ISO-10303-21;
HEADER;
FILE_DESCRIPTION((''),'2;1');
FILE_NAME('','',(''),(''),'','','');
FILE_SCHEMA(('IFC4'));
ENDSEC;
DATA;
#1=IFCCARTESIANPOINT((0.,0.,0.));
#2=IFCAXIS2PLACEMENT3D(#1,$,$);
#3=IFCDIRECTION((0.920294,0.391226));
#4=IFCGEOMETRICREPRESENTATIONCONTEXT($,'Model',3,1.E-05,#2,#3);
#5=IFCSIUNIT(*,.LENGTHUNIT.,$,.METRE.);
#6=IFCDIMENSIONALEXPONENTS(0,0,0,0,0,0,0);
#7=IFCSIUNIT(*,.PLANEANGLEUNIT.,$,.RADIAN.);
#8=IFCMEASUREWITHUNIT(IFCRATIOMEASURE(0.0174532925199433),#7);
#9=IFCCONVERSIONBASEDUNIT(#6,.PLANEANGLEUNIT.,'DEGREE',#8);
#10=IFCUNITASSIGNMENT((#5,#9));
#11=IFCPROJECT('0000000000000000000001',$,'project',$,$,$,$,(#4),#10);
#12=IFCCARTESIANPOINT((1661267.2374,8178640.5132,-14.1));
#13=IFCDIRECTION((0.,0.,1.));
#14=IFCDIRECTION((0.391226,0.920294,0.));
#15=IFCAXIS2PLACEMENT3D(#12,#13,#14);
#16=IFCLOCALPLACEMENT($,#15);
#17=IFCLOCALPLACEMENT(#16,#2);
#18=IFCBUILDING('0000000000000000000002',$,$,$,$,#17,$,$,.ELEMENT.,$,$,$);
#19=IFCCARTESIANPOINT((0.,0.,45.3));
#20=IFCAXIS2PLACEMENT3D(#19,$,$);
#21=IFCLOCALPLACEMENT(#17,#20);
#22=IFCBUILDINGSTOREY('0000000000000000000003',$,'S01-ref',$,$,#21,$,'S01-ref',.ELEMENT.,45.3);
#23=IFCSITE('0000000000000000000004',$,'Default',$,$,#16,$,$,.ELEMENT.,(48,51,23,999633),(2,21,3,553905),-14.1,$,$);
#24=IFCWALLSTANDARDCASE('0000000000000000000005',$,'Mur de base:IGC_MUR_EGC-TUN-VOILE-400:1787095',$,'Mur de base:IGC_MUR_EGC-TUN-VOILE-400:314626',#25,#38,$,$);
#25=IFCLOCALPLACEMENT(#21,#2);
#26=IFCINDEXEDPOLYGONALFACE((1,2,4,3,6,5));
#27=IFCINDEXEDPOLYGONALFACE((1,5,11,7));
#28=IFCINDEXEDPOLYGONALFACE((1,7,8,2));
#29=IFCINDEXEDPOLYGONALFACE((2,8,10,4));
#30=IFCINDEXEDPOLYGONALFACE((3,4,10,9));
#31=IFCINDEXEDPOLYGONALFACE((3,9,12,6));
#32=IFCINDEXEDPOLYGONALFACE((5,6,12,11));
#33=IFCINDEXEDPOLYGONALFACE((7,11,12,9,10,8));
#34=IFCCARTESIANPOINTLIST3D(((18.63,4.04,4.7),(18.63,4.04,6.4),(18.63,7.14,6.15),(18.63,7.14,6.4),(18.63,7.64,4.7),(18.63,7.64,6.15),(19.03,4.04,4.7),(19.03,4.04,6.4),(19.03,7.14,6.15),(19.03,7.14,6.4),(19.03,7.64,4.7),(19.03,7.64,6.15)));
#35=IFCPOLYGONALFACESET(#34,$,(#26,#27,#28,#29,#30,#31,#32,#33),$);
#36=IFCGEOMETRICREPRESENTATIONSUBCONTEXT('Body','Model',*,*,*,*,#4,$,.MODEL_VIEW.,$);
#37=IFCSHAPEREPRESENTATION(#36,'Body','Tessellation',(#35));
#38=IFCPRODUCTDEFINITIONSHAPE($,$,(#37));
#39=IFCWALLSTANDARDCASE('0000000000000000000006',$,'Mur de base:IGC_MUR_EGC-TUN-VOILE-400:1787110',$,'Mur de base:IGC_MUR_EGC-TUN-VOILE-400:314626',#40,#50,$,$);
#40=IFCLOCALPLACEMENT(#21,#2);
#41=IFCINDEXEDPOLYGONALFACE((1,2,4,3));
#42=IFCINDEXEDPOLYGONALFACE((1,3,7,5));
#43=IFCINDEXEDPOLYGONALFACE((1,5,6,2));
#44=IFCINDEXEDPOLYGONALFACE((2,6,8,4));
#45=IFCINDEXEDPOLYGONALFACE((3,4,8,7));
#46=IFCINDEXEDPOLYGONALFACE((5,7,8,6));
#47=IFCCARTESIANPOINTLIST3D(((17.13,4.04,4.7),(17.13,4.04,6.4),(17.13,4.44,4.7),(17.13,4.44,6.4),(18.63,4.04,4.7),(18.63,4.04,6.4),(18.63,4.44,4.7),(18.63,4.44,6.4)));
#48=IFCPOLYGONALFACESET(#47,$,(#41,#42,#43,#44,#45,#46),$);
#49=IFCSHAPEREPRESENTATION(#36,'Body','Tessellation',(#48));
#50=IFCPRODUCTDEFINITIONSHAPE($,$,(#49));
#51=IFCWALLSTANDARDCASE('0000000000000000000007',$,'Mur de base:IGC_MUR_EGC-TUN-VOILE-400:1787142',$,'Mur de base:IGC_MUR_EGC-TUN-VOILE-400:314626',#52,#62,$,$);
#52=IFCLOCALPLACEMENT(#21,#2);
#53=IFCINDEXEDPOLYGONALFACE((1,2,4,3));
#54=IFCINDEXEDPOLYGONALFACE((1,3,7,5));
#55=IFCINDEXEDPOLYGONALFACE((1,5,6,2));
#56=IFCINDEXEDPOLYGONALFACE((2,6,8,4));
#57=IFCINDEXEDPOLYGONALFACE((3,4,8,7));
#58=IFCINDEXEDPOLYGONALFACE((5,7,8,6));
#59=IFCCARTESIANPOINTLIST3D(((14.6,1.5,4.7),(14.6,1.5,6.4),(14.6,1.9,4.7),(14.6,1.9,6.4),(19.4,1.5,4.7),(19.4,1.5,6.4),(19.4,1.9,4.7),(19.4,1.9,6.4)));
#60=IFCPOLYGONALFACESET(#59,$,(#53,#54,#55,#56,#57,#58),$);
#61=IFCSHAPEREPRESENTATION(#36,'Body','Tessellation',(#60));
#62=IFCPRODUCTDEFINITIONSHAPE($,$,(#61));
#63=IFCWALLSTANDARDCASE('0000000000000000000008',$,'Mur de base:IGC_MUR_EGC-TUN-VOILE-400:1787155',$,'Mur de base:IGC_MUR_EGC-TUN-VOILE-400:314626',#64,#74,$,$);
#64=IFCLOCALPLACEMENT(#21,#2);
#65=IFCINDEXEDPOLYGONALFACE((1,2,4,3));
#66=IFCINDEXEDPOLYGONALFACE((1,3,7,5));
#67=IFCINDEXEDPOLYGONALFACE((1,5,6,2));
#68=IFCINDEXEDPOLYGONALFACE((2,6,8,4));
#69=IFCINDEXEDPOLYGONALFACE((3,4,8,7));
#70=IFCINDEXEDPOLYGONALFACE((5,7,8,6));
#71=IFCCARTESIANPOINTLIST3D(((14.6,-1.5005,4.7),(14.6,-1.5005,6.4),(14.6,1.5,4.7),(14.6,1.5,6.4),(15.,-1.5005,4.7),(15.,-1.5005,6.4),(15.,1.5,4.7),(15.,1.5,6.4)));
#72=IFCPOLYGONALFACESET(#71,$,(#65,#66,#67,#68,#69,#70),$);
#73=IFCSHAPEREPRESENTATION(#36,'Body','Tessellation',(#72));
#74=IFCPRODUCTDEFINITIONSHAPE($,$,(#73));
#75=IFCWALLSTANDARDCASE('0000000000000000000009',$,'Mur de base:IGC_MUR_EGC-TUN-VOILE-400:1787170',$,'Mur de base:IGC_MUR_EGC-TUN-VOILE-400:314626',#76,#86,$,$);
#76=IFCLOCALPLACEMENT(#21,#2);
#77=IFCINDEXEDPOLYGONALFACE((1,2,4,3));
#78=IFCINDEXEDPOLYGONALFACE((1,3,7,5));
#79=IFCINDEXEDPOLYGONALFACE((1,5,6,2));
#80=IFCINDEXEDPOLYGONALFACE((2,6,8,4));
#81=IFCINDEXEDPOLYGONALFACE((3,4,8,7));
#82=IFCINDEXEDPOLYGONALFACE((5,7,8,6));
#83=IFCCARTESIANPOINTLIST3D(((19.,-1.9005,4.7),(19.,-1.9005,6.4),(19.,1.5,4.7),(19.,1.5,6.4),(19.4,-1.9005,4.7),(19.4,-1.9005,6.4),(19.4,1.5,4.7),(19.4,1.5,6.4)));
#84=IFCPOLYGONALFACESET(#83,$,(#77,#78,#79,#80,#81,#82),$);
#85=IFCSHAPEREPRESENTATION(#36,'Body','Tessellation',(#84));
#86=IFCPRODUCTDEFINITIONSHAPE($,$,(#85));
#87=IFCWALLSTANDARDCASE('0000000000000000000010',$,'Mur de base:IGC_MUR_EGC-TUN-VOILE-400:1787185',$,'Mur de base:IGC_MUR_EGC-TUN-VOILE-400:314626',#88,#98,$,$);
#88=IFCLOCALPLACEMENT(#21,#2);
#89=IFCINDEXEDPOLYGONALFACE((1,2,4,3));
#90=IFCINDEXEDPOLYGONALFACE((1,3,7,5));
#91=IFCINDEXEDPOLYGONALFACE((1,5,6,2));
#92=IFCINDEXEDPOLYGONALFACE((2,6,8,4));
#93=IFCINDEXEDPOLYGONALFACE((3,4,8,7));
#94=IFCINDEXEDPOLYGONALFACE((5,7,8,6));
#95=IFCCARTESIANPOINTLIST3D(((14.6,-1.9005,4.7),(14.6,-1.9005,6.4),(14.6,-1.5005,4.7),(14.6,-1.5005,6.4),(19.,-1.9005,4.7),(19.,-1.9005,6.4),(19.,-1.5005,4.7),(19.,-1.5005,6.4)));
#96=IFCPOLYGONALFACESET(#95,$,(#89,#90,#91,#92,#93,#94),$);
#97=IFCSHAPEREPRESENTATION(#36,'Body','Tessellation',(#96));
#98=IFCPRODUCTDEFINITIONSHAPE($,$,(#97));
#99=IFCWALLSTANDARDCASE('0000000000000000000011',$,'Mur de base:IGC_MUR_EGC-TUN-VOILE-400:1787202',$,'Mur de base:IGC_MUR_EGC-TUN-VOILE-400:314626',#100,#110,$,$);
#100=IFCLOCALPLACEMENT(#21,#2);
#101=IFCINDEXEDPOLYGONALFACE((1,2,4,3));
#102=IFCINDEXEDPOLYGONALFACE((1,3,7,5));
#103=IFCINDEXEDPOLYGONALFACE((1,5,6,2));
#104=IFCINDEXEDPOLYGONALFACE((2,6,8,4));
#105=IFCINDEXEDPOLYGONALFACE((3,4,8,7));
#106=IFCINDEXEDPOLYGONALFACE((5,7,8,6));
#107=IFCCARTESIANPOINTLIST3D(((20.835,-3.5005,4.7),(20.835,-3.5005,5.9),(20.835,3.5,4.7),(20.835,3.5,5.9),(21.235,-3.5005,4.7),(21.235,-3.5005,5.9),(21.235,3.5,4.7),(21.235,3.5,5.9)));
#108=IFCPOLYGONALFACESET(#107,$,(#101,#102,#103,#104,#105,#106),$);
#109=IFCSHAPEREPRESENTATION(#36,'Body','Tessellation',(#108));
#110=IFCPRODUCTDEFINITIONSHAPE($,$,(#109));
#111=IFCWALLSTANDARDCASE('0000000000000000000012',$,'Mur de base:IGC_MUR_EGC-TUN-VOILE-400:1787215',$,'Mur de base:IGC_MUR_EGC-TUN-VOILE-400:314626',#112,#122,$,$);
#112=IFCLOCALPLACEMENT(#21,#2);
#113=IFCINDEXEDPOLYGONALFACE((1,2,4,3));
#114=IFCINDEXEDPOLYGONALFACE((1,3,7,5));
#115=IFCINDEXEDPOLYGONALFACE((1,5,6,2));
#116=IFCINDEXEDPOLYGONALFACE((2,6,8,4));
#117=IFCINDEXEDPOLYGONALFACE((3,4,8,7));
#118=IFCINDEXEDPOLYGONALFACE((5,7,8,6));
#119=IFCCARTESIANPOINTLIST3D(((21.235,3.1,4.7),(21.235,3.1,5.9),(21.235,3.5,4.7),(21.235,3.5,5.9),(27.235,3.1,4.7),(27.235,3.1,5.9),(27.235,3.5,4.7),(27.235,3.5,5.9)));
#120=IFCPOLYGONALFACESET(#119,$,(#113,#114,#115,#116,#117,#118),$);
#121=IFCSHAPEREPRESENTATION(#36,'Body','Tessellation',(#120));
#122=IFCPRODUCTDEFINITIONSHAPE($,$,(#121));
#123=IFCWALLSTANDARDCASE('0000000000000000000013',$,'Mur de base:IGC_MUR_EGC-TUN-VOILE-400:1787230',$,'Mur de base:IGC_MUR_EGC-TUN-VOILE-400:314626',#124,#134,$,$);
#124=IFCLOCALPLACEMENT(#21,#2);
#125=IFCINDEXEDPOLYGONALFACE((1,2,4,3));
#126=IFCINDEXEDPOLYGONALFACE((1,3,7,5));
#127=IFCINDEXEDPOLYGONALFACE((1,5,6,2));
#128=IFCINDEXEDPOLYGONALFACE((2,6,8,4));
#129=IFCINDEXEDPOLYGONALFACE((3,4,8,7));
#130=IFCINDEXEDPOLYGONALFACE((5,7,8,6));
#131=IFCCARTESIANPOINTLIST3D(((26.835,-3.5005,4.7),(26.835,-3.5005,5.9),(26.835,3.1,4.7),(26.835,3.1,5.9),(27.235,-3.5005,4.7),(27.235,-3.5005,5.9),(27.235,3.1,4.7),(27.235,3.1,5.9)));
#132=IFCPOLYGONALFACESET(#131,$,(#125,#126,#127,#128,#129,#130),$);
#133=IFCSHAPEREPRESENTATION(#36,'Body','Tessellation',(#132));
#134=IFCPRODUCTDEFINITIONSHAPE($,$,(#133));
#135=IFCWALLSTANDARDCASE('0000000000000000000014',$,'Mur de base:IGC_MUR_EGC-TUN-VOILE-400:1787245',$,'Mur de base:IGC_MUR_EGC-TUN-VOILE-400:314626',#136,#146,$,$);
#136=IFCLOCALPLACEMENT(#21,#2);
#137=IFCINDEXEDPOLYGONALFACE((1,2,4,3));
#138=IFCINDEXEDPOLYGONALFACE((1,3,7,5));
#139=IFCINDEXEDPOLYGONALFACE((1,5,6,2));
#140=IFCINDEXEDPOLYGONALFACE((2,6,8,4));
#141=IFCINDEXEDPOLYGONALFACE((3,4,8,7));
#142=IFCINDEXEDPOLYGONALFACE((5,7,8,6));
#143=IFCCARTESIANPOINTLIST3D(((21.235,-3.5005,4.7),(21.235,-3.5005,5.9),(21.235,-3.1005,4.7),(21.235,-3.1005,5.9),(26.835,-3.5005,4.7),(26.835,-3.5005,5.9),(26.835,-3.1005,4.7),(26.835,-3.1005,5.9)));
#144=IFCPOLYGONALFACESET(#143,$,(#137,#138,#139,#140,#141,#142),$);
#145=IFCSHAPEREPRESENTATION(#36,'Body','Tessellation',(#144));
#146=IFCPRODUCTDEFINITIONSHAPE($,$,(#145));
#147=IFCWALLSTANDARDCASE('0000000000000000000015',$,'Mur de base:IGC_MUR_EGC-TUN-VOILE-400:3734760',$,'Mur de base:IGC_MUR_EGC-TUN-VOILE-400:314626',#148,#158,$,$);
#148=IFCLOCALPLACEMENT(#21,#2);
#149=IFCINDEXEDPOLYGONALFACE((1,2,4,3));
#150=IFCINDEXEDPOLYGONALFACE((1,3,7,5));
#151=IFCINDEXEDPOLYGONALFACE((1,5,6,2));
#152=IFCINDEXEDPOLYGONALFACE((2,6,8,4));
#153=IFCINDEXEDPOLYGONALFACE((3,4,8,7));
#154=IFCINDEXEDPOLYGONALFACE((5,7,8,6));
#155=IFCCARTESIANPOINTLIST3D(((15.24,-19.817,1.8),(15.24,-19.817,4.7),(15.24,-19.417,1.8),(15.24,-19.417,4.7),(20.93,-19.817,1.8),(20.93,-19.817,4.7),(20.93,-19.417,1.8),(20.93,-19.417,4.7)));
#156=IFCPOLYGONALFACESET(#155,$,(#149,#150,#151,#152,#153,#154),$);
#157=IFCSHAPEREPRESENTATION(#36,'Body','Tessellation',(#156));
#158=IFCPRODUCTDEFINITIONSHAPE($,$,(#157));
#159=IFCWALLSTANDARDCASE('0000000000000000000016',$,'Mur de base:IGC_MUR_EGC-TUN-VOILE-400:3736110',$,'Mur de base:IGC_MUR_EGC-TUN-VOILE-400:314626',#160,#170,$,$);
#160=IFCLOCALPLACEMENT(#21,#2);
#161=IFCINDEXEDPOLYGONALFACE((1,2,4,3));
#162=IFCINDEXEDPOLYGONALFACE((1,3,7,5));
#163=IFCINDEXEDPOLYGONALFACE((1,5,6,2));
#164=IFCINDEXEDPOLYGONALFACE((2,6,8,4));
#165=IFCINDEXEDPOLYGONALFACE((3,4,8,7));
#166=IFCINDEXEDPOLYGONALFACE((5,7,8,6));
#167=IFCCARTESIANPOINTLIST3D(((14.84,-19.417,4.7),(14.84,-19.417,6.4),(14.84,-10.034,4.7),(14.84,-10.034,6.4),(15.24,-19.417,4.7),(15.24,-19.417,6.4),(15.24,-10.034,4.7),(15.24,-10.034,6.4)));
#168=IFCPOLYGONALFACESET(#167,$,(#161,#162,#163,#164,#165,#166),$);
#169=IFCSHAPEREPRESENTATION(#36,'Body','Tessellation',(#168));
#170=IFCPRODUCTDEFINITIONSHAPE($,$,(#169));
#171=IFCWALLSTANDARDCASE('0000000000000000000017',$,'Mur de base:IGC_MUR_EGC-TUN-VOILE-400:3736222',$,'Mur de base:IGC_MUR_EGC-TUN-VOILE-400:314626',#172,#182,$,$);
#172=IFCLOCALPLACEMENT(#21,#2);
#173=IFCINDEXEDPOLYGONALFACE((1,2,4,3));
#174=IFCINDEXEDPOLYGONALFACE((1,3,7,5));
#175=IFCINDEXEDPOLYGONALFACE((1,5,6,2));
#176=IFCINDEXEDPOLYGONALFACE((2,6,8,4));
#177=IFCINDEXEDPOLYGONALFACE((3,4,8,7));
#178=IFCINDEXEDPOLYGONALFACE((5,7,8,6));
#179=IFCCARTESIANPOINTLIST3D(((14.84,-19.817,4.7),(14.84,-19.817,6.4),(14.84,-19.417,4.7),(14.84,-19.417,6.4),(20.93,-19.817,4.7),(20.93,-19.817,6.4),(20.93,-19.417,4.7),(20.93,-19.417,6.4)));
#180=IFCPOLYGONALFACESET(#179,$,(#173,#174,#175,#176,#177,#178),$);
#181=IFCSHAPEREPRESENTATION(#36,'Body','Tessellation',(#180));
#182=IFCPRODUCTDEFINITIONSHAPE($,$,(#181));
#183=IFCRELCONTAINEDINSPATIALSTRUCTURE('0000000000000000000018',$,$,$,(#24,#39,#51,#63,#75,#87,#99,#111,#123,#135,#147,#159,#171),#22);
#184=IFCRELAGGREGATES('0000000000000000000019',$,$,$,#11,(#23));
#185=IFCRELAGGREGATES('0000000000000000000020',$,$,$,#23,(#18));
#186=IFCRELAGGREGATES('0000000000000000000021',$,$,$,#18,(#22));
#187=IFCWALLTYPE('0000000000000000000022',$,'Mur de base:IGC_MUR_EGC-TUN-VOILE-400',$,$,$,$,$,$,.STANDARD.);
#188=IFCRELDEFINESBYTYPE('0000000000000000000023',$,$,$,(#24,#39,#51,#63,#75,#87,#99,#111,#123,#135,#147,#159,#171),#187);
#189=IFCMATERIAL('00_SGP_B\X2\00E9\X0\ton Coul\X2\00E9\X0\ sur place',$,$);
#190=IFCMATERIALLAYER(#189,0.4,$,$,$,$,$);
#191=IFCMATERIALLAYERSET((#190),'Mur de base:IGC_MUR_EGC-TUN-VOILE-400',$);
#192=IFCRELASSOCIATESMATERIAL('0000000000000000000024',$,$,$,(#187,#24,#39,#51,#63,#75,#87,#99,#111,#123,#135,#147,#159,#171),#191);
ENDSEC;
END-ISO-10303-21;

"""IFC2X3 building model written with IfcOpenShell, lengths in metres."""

from ifc_helpers import new_model, entity, si_unit, converted_unit, direction, frame, frame_2d, origin, place, context, subcontext, project, spatial, rectangle, extrude, material, layer, layer_set, layer_usage, type_object, element, save


model = new_model("IFC2X3")

# Units and contexts
model_context = context("Model", 3, precision=1e-05, world=origin(), true_north=direction((0.920294, 0.391226)))
body_context = subcontext(model_context, "Body", "Model", "MODEL_VIEW")
ifc_project = project(units=[si_unit("LENGTHUNIT", "METRE"), converted_unit("PLANEANGLEUNIT", "DEGREE", entity("IfcRatioMeasure", 0.0174532925199433), si_unit("PLANEANGLEUNIT", "RADIAN"), dimensions=[0, 0, 0, 0, 0, 0, 0])], contexts=[model_context])

# Site, building, storey
site_placement = place(None, frame((1661267.2374, 8178640.5132, -14.1), z_axis=(0.0, 0.0, 1.0), x_axis=(0.391226, 0.920294, 0.0)))
site = spatial("IfcSite", under=ifc_project, at=site_placement, Name="Default", CompositionType="ELEMENT", RefLatitude=(48, 51, 23, 999633), RefLongitude=(2, 21, 3, 553905), RefElevation=-14.1)
building_placement = place(site_placement, origin())
building = spatial("IfcBuilding", under=site, at=building_placement, CompositionType="ELEMENT")
storey_placement = place(building_placement, frame((0.0, 0.0, 45.3)))
storey = spatial("IfcBuildingStorey", under=building, at=storey_placement, Name="S01-ref", LongName="S01-ref", CompositionType="ELEMENT", Elevation=45.3)

# Shared definitions
ifc_material = material(Name="00_SGP_Béton Coulé sur place")
ifc_layer_1 = layer(ifc_material, 0.4)
ifc_layer_set_1 = layer_set([ifc_layer_1], Name="Mur de base:IGC_MUR_EGC-TUN-VOILE-400")
wall_type_1 = type_object("IfcWallType", Name="Mur de base:IGC_MUR_EGC-TUN-VOILE-400", PredefinedType="STANDARD", material=ifc_layer_set_1)

# Wall, opening
ifc_layer_usage_1 = layer_usage(ifc_layer_set_1, "AXIS2", "NEGATIVE", 0.2)
wall_1_placement = place(storey_placement, frame((18.83, 7.64, 4.7), z_axis=(0.0, 0.0, 1.0), x_axis=(0.0, -1.0, 0.0)))
wall_1 = element("IfcWallStandardCase", 1, at=wall_1_placement, inside=storey, type_object=wall_type_1, material=ifc_layer_usage_1, Name="Mur de base:IGC_MUR_EGC-TUN-VOILE-400:1787095", ObjectType="Mur de base:IGC_MUR_EGC-TUN-VOILE-400:314626", context=body_context, shape_type="SweptSolid", body=[
    extrude(rectangle(XDim=3.6, YDim=0.4, at=frame_2d((1.8, 0.0), x_axis=(-1.0, 0.0))), origin(), (0.0, 0.0, 1.0), 1.7),
])
opening_1_placement = place(wall_1_placement, origin())
element("IfcOpeningElement", 2, at=opening_1_placement, cuts=wall_1, ObjectType="Opening", context=body_context, shape_type="SweptSolid", body=[
    extrude(rectangle(XDim=0.25, YDim=0.5, at=frame_2d((0.0, 0.0), x_axis=(0.0, 1.0))), frame((0.25, -1.724, 1.575), z_axis=(0.0, 1.0, 0.0), x_axis=(1.0, 0.0, 0.0)), (0.0, 0.0, 1.0), 3.048),
])

# Wall
ifc_layer_usage_2 = layer_usage(ifc_layer_set_1, "AXIS2", "NEGATIVE", 0.2)
wall_2_placement = place(storey_placement, frame((18.63, 4.24, 4.7), z_axis=(0.0, 0.0, 1.0), x_axis=(-1.0, 0.0, 0.0)))
element("IfcWallStandardCase", 3, at=wall_2_placement, inside=storey, type_object=wall_type_1, material=ifc_layer_usage_2, Name="Mur de base:IGC_MUR_EGC-TUN-VOILE-400:1787110", ObjectType="Mur de base:IGC_MUR_EGC-TUN-VOILE-400:314626", context=body_context, shape_type="SweptSolid", body=[
    extrude(rectangle(XDim=1.5, YDim=0.4, at=frame_2d((0.75, 0.0), x_axis=(-1.0, 0.0))), origin(), (0.0, 0.0, 1.0), 1.7),
])

# Walls
ifc_layer_usage_3 = layer_usage(ifc_layer_set_1, "AXIS2", "NEGATIVE", 0.2)
wall_3_placement = place(storey_placement, frame((14.6, 1.7, 4.7)))
element("IfcWallStandardCase", 4, at=wall_3_placement, inside=storey, type_object=wall_type_1, material=ifc_layer_usage_3, Name="Mur de base:IGC_MUR_EGC-TUN-VOILE-400:1787142", ObjectType="Mur de base:IGC_MUR_EGC-TUN-VOILE-400:314626", context=body_context, shape_type="SweptSolid", body=[
    extrude(rectangle(XDim=4.8, YDim=0.4, at=frame_2d((2.4, 0.0), x_axis=(-1.0, 0.0))), origin(), (0.0, 0.0, 1.0), 1.7),
])
ifc_layer_usage_4 = layer_usage(ifc_layer_set_1, "AXIS2", "NEGATIVE", 0.2)
wall_4_placement = place(storey_placement, frame((14.8, -1.5005, 4.7), z_axis=(0.0, 0.0, 1.0), x_axis=(0.0, 1.0, 0.0)))
element("IfcWallStandardCase", 5, at=wall_4_placement, inside=storey, type_object=wall_type_1, material=ifc_layer_usage_4, Name="Mur de base:IGC_MUR_EGC-TUN-VOILE-400:1787155", ObjectType="Mur de base:IGC_MUR_EGC-TUN-VOILE-400:314626", context=body_context, shape_type="SweptSolid", body=[
    extrude(rectangle(XDim=3.0005, YDim=0.4, at=frame_2d((1.5002, 0.0), x_axis=(-1.0, 0.0))), origin(), (0.0, 0.0, 1.0), 1.7),
])
ifc_layer_usage_5 = layer_usage(ifc_layer_set_1, "AXIS2", "NEGATIVE", 0.2)
wall_5_placement = place(storey_placement, frame((19.2, 1.5, 4.7), z_axis=(0.0, 0.0, 1.0), x_axis=(0.0, -1.0, 0.0)))
element("IfcWallStandardCase", 6, at=wall_5_placement, inside=storey, type_object=wall_type_1, material=ifc_layer_usage_5, Name="Mur de base:IGC_MUR_EGC-TUN-VOILE-400:1787170", ObjectType="Mur de base:IGC_MUR_EGC-TUN-VOILE-400:314626", context=body_context, shape_type="SweptSolid", body=[
    extrude(rectangle(XDim=3.4005, YDim=0.4, at=frame_2d((1.7002, 0.0), x_axis=(-1.0, 0.0))), origin(), (0.0, 0.0, 1.0), 1.7),
])
ifc_layer_usage_6 = layer_usage(ifc_layer_set_1, "AXIS2", "NEGATIVE", 0.2)
wall_6_placement = place(storey_placement, frame((19.0, -1.7005, 4.7), z_axis=(0.0, 0.0, 1.0), x_axis=(-1.0, 0.0, 0.0)))
element("IfcWallStandardCase", 7, at=wall_6_placement, inside=storey, type_object=wall_type_1, material=ifc_layer_usage_6, Name="Mur de base:IGC_MUR_EGC-TUN-VOILE-400:1787185", ObjectType="Mur de base:IGC_MUR_EGC-TUN-VOILE-400:314626", context=body_context, shape_type="SweptSolid", body=[
    extrude(rectangle(XDim=4.4, YDim=0.4, at=frame_2d((2.2, 0.0), x_axis=(-1.0, 0.0))), origin(), (0.0, 0.0, 1.0), 1.7),
])
ifc_layer_usage_7 = layer_usage(ifc_layer_set_1, "AXIS2", "NEGATIVE", 0.2)
wall_7_placement = place(storey_placement, frame((21.035, -3.5005, 4.7), z_axis=(0.0, 0.0, 1.0), x_axis=(0.0, 1.0, 0.0)))
element("IfcWallStandardCase", 8, at=wall_7_placement, inside=storey, type_object=wall_type_1, material=ifc_layer_usage_7, Name="Mur de base:IGC_MUR_EGC-TUN-VOILE-400:1787202", ObjectType="Mur de base:IGC_MUR_EGC-TUN-VOILE-400:314626", context=body_context, shape_type="SweptSolid", body=[
    extrude(rectangle(XDim=7.0005, YDim=0.4, at=frame_2d((3.5002, 0.0), x_axis=(-1.0, 0.0))), origin(), (0.0, 0.0, 1.0), 1.2),
])
ifc_layer_usage_8 = layer_usage(ifc_layer_set_1, "AXIS2", "NEGATIVE", 0.2)
wall_8_placement = place(storey_placement, frame((21.235, 3.3, 4.7)))
element("IfcWallStandardCase", 9, at=wall_8_placement, inside=storey, type_object=wall_type_1, material=ifc_layer_usage_8, Name="Mur de base:IGC_MUR_EGC-TUN-VOILE-400:1787215", ObjectType="Mur de base:IGC_MUR_EGC-TUN-VOILE-400:314626", context=body_context, shape_type="SweptSolid", body=[
    extrude(rectangle(XDim=6.0, YDim=0.4, at=frame_2d((3.0, 0.0), x_axis=(-1.0, 0.0))), origin(), (0.0, 0.0, 1.0), 1.2),
])
ifc_layer_usage_9 = layer_usage(ifc_layer_set_1, "AXIS2", "NEGATIVE", 0.2)
wall_9_placement = place(storey_placement, frame((27.035, 3.1, 4.7), z_axis=(0.0, 0.0, 1.0), x_axis=(0.0, -1.0, 0.0)))
element("IfcWallStandardCase", 10, at=wall_9_placement, inside=storey, type_object=wall_type_1, material=ifc_layer_usage_9, Name="Mur de base:IGC_MUR_EGC-TUN-VOILE-400:1787230", ObjectType="Mur de base:IGC_MUR_EGC-TUN-VOILE-400:314626", context=body_context, shape_type="SweptSolid", body=[
    extrude(rectangle(XDim=6.6005, YDim=0.4, at=frame_2d((3.3002, 0.0), x_axis=(-1.0, 0.0))), origin(), (0.0, 0.0, 1.0), 1.2),
])
ifc_layer_usage_10 = layer_usage(ifc_layer_set_1, "AXIS2", "NEGATIVE", 0.2)
wall_10_placement = place(storey_placement, frame((26.835, -3.3005, 4.7), z_axis=(0.0, 0.0, 1.0), x_axis=(-1.0, 0.0, 0.0)))
element("IfcWallStandardCase", 11, at=wall_10_placement, inside=storey, type_object=wall_type_1, material=ifc_layer_usage_10, Name="Mur de base:IGC_MUR_EGC-TUN-VOILE-400:1787245", ObjectType="Mur de base:IGC_MUR_EGC-TUN-VOILE-400:314626", context=body_context, shape_type="SweptSolid", body=[
    extrude(rectangle(XDim=5.6, YDim=0.4, at=frame_2d((2.8, 0.0), x_axis=(-1.0, 0.0))), origin(), (0.0, 0.0, 1.0), 1.2),
])
ifc_layer_usage_11 = layer_usage(ifc_layer_set_1, "AXIS2", "NEGATIVE", 0.2)
wall_11_placement = place(storey_placement, frame((15.24, -19.617, 1.8)))
element("IfcWallStandardCase", 12, at=wall_11_placement, inside=storey, type_object=wall_type_1, material=ifc_layer_usage_11, Name="Mur de base:IGC_MUR_EGC-TUN-VOILE-400:3734760", ObjectType="Mur de base:IGC_MUR_EGC-TUN-VOILE-400:314626", context=body_context, shape_type="SweptSolid", body=[
    extrude(rectangle(XDim=5.69, YDim=0.4, at=frame_2d((2.845, 0.0), x_axis=(-1.0, 0.0))), origin(), (0.0, 0.0, 1.0), 2.9),
])
ifc_layer_usage_12 = layer_usage(ifc_layer_set_1, "AXIS2", "NEGATIVE", 0.2)
wall_12_placement = place(storey_placement, frame((15.04, -10.034, 4.7), z_axis=(0.0, 0.0, 1.0), x_axis=(0.0, -1.0, 0.0)))
element("IfcWallStandardCase", 13, at=wall_12_placement, inside=storey, type_object=wall_type_1, material=ifc_layer_usage_12, Name="Mur de base:IGC_MUR_EGC-TUN-VOILE-400:3736110", ObjectType="Mur de base:IGC_MUR_EGC-TUN-VOILE-400:314626", context=body_context, shape_type="SweptSolid", body=[
    extrude(rectangle(XDim=9.383, YDim=0.4, at=frame_2d((4.6915, 0.0), x_axis=(-1.0, 0.0))), origin(), (0.0, 0.0, 1.0), 1.7),
])
ifc_layer_usage_13 = layer_usage(ifc_layer_set_1, "AXIS2", "NEGATIVE", 0.2)
wall_13_placement = place(storey_placement, frame((14.84, -19.617, 4.7)))
element("IfcWallStandardCase", 14, at=wall_13_placement, inside=storey, type_object=wall_type_1, material=ifc_layer_usage_13, Name="Mur de base:IGC_MUR_EGC-TUN-VOILE-400:3736222", ObjectType="Mur de base:IGC_MUR_EGC-TUN-VOILE-400:314626", context=body_context, shape_type="SweptSolid", body=[
    extrude(rectangle(XDim=6.09, YDim=0.4, at=frame_2d((3.045, 0.0), x_axis=(-1.0, 0.0))), origin(), (0.0, 0.0, 1.0), 1.7),
])

save(model, "model.ifc")
